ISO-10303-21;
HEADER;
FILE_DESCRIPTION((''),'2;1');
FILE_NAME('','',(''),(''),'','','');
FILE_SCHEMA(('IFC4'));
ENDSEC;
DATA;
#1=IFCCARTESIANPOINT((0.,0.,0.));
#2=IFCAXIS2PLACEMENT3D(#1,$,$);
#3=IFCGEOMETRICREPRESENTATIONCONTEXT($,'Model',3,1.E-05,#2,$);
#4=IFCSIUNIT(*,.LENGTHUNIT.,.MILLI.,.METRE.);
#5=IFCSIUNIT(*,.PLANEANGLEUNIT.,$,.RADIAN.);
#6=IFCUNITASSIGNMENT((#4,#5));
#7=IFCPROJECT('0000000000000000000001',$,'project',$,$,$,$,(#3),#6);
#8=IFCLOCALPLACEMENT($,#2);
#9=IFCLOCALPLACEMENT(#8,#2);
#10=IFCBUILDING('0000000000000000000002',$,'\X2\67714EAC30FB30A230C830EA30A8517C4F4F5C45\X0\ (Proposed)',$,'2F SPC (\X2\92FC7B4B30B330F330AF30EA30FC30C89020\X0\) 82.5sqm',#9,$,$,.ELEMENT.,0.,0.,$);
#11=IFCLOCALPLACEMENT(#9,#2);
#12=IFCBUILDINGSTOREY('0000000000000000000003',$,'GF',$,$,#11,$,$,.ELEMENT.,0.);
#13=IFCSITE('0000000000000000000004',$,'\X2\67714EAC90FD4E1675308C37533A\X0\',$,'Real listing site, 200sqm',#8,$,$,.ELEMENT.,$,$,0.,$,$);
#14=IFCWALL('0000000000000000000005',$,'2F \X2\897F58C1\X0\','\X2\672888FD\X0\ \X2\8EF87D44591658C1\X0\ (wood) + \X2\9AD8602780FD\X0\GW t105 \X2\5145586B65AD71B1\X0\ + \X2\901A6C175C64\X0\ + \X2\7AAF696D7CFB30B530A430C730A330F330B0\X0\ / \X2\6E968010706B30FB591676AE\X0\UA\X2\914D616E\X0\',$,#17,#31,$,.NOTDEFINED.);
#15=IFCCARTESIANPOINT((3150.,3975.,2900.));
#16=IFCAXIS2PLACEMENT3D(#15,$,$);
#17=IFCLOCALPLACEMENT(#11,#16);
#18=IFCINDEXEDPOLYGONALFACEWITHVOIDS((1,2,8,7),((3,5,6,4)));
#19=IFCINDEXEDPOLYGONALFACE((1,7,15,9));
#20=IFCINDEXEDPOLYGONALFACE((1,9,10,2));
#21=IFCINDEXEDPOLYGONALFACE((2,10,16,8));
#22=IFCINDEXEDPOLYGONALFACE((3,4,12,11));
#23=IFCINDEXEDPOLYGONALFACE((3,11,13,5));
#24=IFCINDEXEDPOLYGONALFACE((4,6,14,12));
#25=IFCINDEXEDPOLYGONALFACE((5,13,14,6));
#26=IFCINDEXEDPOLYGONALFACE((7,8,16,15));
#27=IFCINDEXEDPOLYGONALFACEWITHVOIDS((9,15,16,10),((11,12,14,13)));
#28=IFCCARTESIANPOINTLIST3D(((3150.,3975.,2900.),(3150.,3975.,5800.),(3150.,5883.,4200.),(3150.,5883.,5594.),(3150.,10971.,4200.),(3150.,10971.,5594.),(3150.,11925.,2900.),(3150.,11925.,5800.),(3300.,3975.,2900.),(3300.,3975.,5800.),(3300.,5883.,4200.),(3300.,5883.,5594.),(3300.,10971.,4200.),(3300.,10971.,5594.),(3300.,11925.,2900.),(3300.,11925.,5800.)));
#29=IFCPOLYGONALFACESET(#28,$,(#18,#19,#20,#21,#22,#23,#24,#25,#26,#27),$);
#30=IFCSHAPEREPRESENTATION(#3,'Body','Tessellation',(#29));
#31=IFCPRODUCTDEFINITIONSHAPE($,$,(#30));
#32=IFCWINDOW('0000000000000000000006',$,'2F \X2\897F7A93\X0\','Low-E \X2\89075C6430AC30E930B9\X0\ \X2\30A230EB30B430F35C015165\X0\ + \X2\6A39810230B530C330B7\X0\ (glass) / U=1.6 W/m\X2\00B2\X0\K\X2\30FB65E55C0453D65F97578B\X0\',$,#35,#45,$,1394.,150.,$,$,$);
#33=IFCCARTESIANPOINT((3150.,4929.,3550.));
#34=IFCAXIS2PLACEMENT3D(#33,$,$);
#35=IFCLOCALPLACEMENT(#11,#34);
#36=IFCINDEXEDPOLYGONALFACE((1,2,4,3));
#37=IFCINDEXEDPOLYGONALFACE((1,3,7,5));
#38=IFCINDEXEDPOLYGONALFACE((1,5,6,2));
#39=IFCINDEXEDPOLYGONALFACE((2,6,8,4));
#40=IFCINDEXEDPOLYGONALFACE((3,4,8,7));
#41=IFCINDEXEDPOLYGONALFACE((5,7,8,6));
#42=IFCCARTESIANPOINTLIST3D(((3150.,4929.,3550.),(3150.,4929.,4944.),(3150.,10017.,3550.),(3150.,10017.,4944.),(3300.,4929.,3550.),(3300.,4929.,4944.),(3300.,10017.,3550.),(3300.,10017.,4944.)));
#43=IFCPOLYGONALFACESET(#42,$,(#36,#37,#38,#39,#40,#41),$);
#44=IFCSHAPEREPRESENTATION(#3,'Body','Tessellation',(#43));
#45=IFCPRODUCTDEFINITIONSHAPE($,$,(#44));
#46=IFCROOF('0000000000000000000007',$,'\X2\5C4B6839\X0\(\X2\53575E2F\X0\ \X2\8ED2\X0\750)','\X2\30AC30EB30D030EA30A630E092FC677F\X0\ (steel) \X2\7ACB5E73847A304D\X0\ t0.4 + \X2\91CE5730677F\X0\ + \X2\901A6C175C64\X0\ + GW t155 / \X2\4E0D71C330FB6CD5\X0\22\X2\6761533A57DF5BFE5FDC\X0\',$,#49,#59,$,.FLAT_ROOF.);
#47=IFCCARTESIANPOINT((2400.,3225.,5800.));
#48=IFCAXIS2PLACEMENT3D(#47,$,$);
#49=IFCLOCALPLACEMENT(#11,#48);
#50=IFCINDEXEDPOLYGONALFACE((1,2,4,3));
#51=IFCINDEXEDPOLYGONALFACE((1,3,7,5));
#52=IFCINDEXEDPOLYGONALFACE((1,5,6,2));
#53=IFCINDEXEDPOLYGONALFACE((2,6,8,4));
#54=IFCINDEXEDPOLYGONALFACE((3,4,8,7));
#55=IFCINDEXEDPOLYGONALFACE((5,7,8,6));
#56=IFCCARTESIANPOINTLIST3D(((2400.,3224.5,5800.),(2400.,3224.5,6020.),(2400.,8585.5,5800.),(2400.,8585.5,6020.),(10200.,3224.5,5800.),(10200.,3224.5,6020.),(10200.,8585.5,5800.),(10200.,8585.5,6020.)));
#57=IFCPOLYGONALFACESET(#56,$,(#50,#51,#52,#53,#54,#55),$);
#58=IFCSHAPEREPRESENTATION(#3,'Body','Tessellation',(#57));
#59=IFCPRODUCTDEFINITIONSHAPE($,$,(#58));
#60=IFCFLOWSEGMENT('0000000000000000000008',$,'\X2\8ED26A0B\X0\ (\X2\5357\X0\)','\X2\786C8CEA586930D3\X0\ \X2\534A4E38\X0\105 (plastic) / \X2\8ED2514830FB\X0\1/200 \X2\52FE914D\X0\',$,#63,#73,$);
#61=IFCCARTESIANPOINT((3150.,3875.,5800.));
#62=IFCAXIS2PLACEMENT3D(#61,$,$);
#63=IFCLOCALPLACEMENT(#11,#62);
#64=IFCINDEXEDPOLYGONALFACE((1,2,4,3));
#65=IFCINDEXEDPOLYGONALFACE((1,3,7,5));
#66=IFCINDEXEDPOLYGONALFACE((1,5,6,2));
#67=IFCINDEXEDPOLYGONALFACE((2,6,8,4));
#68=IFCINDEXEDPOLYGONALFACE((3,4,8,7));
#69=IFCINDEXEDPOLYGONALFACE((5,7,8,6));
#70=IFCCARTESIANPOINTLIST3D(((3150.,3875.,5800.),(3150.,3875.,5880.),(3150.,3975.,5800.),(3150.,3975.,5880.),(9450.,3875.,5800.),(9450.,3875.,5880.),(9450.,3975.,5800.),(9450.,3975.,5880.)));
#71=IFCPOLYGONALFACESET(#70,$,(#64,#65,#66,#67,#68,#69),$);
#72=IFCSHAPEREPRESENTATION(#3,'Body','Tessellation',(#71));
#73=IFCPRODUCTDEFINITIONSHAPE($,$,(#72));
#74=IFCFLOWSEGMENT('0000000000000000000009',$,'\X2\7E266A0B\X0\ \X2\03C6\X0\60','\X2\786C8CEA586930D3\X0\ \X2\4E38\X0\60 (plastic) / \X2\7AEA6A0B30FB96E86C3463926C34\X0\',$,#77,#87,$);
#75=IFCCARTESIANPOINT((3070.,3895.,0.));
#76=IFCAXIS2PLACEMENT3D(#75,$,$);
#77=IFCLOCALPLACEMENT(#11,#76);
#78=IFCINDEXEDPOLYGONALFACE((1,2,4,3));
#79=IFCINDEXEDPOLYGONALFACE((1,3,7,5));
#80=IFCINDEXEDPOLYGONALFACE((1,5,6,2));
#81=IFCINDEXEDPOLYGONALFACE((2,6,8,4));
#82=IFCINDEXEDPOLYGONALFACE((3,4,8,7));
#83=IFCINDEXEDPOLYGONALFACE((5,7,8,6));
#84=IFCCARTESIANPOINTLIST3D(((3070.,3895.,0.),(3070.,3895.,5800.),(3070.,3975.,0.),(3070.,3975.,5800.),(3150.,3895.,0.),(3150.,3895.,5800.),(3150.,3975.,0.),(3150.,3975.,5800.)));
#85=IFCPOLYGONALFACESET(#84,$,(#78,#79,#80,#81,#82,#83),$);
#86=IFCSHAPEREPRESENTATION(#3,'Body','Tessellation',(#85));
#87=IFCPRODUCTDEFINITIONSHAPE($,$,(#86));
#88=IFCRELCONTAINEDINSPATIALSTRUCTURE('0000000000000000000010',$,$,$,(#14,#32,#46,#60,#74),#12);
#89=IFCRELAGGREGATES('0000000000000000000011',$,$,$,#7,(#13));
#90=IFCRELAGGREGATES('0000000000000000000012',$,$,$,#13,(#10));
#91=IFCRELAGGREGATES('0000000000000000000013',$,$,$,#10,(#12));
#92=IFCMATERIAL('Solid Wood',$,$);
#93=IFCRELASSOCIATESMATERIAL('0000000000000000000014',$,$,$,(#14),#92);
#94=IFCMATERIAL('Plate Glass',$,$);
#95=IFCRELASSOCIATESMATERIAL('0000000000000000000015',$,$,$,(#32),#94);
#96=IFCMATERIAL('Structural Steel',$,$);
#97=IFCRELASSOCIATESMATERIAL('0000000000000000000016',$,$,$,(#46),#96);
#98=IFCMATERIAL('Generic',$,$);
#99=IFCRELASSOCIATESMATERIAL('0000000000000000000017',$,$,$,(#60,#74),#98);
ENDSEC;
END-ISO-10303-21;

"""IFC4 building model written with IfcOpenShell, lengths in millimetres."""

from ifc_helpers import new_model, si_unit, frame, frame_2d, origin, place, context, project, spatial, rectangle, extrude, material, element, fill, save


model = new_model("IFC4")

# Units and contexts
model_context = context("Model", 3, precision=1e-05, world=origin())
ifc_project = project(units=[si_unit("LENGTHUNIT", "METRE", prefix="MILLI"), si_unit("PLANEANGLEUNIT", "RADIAN")], contexts=[model_context])

# Site, building, storey
site_placement = place(None, origin())
site = spatial("IfcSite", under=ifc_project, at=site_placement, Name="東京都世田谷区", ObjectType="Real listing site, 200sqm", CompositionType="ELEMENT", RefElevation=0.0)
building_placement = place(site_placement, origin())
building = spatial("IfcBuilding", under=site, at=building_placement, Name="東京・アトリエ兼住居 (Proposed)", ObjectType="2F SPC (鋼筋コンクリート造) 82.5sqm", CompositionType="ELEMENT", ElevationOfRefHeight=0.0, ElevationOfTerrain=0.0)
storey_placement = place(building_placement, origin())
storey = spatial("IfcBuildingStorey", under=building, at=storey_placement, Name="GF", CompositionType="ELEMENT", Elevation=0.0)

# Shared definitions
ifc_material_1 = material(Name="Solid Wood")

# Shared definitions
ifc_material_2 = material(Name="Plate Glass")

# Wall, opening, window
wall_1_placement = place(storey_placement, frame((3150.0, 3975.0, 2900.0)))
wall_1 = element("IfcWall", 1, at=wall_1_placement, inside=storey, material=ifc_material_1, Name="2F 西壁", Description="木製 軸組外壁 (wood) + 高性能GW t105 充填断熱 + 通気層 + 窯業系サイディング / 準耐火・外皮UA配慮", PredefinedType="NOTDEFINED", context=model_context, shape_type="SweptSolid", body=[
    extrude(rectangle(XDim=150.0, YDim=7950.0, at=frame_2d((75.0, 3975.0))), frame((3150.0, 3975.0, 2900.0)), (0.0, 0.0, 1.0), 2900.0),
])
opening_1_placement = place(storey_placement, frame((3150.0, 4929.0, 3550.0)))
opening_1 = element("IfcOpeningElement", 2, at=opening_1_placement, cuts=wall_1, PredefinedType="NOTDEFINED", context=model_context, shape_type="SweptSolid", body=[
    extrude(rectangle(XDim=150.0, YDim=5088.0, at=frame_2d((75.0, 2544.0))), frame((3150.0, 4929.0, 3550.0)), (0.0, 0.0, 1.0), 1394.0),
])
window_1_placement = place(storey_placement, frame((3150.0, 4929.0, 3550.0)))
window_1 = element("IfcWindow", 3, at=window_1_placement, inside=storey, material=ifc_material_2, Name="2F 西窓", Description="Low-E 複層ガラス アルゴン封入 + 樹脂サッシ (glass) / U=1.6 W/m²K・日射取得型", OverallHeight=1394.0, OverallWidth=150.0, context=model_context, shape_type="SweptSolid", body=[
    extrude(rectangle(XDim=150.0, YDim=5088.0, at=frame_2d((75.0, 2544.0))), frame((3150.0, 4929.0, 3550.0)), (0.0, 0.0, 1.0), 1394.0),
])
fill(opening_1, window_1)

# Roof
ifc_material_3 = material(Name="Structural Steel")
for number, where, name in (
    (4, (2400.0, 3225.0, 5800.0), "屋根(南帯 軒750)"),
):
    element("IfcRoof", number, at=place(storey_placement, frame(where)), inside=storey, material=ifc_material_3, Name=name, Description="ガルバリウム鋼板 (steel) 立平葺き t0.4 + 野地板 + 通気層 + GW t155 / 不燃・法22条区域対応", PredefinedType="FLAT_ROOF", context=model_context, shape_type="SweptSolid", body=[
        extrude(rectangle(XDim=7800.0, YDim=5361.0, at=frame_2d((3900.0, 2680.0))), frame((2400.0, 3225.0, 5800.0)), (0.0, 0.0, 1.0), 220.0),
    ])

# Flow segments
ifc_material_4 = material(Name="Generic")
flow_segment_1_placement = place(storey_placement, frame((3150.0, 3875.0, 5800.0)))
element("IfcFlowSegment", 5, at=flow_segment_1_placement, inside=storey, material=ifc_material_4, Name="軒樋 (南)", Description="硬質塩ビ 半丸105 (plastic) / 軒先・1/200 勾配", context=model_context, shape_type="SweptSolid", body=[
    extrude(rectangle(XDim=6300.0, YDim=100.0, at=frame_2d((3150.0, 50.0))), frame((3150.0, 3875.0, 5800.0)), (0.0, 0.0, 1.0), 80.0),
])
flow_segment_2_placement = place(storey_placement, frame((3070.0, 3895.0, 0.0)))
element("IfcFlowSegment", 6, at=flow_segment_2_placement, inside=storey, material=ifc_material_4, Name="縦樋 φ60", Description="硬質塩ビ 丸60 (plastic) / 竪樋・雨水排水", context=model_context, shape_type="SweptSolid", body=[
    extrude(rectangle(XDim=80.0, YDim=80.0, at=frame_2d((40.0, 40.0))), frame((3070.0, 3895.0, 0.0)), (0.0, 0.0, 1.0), 5800.0),
])

save(model, "model.ifc")
